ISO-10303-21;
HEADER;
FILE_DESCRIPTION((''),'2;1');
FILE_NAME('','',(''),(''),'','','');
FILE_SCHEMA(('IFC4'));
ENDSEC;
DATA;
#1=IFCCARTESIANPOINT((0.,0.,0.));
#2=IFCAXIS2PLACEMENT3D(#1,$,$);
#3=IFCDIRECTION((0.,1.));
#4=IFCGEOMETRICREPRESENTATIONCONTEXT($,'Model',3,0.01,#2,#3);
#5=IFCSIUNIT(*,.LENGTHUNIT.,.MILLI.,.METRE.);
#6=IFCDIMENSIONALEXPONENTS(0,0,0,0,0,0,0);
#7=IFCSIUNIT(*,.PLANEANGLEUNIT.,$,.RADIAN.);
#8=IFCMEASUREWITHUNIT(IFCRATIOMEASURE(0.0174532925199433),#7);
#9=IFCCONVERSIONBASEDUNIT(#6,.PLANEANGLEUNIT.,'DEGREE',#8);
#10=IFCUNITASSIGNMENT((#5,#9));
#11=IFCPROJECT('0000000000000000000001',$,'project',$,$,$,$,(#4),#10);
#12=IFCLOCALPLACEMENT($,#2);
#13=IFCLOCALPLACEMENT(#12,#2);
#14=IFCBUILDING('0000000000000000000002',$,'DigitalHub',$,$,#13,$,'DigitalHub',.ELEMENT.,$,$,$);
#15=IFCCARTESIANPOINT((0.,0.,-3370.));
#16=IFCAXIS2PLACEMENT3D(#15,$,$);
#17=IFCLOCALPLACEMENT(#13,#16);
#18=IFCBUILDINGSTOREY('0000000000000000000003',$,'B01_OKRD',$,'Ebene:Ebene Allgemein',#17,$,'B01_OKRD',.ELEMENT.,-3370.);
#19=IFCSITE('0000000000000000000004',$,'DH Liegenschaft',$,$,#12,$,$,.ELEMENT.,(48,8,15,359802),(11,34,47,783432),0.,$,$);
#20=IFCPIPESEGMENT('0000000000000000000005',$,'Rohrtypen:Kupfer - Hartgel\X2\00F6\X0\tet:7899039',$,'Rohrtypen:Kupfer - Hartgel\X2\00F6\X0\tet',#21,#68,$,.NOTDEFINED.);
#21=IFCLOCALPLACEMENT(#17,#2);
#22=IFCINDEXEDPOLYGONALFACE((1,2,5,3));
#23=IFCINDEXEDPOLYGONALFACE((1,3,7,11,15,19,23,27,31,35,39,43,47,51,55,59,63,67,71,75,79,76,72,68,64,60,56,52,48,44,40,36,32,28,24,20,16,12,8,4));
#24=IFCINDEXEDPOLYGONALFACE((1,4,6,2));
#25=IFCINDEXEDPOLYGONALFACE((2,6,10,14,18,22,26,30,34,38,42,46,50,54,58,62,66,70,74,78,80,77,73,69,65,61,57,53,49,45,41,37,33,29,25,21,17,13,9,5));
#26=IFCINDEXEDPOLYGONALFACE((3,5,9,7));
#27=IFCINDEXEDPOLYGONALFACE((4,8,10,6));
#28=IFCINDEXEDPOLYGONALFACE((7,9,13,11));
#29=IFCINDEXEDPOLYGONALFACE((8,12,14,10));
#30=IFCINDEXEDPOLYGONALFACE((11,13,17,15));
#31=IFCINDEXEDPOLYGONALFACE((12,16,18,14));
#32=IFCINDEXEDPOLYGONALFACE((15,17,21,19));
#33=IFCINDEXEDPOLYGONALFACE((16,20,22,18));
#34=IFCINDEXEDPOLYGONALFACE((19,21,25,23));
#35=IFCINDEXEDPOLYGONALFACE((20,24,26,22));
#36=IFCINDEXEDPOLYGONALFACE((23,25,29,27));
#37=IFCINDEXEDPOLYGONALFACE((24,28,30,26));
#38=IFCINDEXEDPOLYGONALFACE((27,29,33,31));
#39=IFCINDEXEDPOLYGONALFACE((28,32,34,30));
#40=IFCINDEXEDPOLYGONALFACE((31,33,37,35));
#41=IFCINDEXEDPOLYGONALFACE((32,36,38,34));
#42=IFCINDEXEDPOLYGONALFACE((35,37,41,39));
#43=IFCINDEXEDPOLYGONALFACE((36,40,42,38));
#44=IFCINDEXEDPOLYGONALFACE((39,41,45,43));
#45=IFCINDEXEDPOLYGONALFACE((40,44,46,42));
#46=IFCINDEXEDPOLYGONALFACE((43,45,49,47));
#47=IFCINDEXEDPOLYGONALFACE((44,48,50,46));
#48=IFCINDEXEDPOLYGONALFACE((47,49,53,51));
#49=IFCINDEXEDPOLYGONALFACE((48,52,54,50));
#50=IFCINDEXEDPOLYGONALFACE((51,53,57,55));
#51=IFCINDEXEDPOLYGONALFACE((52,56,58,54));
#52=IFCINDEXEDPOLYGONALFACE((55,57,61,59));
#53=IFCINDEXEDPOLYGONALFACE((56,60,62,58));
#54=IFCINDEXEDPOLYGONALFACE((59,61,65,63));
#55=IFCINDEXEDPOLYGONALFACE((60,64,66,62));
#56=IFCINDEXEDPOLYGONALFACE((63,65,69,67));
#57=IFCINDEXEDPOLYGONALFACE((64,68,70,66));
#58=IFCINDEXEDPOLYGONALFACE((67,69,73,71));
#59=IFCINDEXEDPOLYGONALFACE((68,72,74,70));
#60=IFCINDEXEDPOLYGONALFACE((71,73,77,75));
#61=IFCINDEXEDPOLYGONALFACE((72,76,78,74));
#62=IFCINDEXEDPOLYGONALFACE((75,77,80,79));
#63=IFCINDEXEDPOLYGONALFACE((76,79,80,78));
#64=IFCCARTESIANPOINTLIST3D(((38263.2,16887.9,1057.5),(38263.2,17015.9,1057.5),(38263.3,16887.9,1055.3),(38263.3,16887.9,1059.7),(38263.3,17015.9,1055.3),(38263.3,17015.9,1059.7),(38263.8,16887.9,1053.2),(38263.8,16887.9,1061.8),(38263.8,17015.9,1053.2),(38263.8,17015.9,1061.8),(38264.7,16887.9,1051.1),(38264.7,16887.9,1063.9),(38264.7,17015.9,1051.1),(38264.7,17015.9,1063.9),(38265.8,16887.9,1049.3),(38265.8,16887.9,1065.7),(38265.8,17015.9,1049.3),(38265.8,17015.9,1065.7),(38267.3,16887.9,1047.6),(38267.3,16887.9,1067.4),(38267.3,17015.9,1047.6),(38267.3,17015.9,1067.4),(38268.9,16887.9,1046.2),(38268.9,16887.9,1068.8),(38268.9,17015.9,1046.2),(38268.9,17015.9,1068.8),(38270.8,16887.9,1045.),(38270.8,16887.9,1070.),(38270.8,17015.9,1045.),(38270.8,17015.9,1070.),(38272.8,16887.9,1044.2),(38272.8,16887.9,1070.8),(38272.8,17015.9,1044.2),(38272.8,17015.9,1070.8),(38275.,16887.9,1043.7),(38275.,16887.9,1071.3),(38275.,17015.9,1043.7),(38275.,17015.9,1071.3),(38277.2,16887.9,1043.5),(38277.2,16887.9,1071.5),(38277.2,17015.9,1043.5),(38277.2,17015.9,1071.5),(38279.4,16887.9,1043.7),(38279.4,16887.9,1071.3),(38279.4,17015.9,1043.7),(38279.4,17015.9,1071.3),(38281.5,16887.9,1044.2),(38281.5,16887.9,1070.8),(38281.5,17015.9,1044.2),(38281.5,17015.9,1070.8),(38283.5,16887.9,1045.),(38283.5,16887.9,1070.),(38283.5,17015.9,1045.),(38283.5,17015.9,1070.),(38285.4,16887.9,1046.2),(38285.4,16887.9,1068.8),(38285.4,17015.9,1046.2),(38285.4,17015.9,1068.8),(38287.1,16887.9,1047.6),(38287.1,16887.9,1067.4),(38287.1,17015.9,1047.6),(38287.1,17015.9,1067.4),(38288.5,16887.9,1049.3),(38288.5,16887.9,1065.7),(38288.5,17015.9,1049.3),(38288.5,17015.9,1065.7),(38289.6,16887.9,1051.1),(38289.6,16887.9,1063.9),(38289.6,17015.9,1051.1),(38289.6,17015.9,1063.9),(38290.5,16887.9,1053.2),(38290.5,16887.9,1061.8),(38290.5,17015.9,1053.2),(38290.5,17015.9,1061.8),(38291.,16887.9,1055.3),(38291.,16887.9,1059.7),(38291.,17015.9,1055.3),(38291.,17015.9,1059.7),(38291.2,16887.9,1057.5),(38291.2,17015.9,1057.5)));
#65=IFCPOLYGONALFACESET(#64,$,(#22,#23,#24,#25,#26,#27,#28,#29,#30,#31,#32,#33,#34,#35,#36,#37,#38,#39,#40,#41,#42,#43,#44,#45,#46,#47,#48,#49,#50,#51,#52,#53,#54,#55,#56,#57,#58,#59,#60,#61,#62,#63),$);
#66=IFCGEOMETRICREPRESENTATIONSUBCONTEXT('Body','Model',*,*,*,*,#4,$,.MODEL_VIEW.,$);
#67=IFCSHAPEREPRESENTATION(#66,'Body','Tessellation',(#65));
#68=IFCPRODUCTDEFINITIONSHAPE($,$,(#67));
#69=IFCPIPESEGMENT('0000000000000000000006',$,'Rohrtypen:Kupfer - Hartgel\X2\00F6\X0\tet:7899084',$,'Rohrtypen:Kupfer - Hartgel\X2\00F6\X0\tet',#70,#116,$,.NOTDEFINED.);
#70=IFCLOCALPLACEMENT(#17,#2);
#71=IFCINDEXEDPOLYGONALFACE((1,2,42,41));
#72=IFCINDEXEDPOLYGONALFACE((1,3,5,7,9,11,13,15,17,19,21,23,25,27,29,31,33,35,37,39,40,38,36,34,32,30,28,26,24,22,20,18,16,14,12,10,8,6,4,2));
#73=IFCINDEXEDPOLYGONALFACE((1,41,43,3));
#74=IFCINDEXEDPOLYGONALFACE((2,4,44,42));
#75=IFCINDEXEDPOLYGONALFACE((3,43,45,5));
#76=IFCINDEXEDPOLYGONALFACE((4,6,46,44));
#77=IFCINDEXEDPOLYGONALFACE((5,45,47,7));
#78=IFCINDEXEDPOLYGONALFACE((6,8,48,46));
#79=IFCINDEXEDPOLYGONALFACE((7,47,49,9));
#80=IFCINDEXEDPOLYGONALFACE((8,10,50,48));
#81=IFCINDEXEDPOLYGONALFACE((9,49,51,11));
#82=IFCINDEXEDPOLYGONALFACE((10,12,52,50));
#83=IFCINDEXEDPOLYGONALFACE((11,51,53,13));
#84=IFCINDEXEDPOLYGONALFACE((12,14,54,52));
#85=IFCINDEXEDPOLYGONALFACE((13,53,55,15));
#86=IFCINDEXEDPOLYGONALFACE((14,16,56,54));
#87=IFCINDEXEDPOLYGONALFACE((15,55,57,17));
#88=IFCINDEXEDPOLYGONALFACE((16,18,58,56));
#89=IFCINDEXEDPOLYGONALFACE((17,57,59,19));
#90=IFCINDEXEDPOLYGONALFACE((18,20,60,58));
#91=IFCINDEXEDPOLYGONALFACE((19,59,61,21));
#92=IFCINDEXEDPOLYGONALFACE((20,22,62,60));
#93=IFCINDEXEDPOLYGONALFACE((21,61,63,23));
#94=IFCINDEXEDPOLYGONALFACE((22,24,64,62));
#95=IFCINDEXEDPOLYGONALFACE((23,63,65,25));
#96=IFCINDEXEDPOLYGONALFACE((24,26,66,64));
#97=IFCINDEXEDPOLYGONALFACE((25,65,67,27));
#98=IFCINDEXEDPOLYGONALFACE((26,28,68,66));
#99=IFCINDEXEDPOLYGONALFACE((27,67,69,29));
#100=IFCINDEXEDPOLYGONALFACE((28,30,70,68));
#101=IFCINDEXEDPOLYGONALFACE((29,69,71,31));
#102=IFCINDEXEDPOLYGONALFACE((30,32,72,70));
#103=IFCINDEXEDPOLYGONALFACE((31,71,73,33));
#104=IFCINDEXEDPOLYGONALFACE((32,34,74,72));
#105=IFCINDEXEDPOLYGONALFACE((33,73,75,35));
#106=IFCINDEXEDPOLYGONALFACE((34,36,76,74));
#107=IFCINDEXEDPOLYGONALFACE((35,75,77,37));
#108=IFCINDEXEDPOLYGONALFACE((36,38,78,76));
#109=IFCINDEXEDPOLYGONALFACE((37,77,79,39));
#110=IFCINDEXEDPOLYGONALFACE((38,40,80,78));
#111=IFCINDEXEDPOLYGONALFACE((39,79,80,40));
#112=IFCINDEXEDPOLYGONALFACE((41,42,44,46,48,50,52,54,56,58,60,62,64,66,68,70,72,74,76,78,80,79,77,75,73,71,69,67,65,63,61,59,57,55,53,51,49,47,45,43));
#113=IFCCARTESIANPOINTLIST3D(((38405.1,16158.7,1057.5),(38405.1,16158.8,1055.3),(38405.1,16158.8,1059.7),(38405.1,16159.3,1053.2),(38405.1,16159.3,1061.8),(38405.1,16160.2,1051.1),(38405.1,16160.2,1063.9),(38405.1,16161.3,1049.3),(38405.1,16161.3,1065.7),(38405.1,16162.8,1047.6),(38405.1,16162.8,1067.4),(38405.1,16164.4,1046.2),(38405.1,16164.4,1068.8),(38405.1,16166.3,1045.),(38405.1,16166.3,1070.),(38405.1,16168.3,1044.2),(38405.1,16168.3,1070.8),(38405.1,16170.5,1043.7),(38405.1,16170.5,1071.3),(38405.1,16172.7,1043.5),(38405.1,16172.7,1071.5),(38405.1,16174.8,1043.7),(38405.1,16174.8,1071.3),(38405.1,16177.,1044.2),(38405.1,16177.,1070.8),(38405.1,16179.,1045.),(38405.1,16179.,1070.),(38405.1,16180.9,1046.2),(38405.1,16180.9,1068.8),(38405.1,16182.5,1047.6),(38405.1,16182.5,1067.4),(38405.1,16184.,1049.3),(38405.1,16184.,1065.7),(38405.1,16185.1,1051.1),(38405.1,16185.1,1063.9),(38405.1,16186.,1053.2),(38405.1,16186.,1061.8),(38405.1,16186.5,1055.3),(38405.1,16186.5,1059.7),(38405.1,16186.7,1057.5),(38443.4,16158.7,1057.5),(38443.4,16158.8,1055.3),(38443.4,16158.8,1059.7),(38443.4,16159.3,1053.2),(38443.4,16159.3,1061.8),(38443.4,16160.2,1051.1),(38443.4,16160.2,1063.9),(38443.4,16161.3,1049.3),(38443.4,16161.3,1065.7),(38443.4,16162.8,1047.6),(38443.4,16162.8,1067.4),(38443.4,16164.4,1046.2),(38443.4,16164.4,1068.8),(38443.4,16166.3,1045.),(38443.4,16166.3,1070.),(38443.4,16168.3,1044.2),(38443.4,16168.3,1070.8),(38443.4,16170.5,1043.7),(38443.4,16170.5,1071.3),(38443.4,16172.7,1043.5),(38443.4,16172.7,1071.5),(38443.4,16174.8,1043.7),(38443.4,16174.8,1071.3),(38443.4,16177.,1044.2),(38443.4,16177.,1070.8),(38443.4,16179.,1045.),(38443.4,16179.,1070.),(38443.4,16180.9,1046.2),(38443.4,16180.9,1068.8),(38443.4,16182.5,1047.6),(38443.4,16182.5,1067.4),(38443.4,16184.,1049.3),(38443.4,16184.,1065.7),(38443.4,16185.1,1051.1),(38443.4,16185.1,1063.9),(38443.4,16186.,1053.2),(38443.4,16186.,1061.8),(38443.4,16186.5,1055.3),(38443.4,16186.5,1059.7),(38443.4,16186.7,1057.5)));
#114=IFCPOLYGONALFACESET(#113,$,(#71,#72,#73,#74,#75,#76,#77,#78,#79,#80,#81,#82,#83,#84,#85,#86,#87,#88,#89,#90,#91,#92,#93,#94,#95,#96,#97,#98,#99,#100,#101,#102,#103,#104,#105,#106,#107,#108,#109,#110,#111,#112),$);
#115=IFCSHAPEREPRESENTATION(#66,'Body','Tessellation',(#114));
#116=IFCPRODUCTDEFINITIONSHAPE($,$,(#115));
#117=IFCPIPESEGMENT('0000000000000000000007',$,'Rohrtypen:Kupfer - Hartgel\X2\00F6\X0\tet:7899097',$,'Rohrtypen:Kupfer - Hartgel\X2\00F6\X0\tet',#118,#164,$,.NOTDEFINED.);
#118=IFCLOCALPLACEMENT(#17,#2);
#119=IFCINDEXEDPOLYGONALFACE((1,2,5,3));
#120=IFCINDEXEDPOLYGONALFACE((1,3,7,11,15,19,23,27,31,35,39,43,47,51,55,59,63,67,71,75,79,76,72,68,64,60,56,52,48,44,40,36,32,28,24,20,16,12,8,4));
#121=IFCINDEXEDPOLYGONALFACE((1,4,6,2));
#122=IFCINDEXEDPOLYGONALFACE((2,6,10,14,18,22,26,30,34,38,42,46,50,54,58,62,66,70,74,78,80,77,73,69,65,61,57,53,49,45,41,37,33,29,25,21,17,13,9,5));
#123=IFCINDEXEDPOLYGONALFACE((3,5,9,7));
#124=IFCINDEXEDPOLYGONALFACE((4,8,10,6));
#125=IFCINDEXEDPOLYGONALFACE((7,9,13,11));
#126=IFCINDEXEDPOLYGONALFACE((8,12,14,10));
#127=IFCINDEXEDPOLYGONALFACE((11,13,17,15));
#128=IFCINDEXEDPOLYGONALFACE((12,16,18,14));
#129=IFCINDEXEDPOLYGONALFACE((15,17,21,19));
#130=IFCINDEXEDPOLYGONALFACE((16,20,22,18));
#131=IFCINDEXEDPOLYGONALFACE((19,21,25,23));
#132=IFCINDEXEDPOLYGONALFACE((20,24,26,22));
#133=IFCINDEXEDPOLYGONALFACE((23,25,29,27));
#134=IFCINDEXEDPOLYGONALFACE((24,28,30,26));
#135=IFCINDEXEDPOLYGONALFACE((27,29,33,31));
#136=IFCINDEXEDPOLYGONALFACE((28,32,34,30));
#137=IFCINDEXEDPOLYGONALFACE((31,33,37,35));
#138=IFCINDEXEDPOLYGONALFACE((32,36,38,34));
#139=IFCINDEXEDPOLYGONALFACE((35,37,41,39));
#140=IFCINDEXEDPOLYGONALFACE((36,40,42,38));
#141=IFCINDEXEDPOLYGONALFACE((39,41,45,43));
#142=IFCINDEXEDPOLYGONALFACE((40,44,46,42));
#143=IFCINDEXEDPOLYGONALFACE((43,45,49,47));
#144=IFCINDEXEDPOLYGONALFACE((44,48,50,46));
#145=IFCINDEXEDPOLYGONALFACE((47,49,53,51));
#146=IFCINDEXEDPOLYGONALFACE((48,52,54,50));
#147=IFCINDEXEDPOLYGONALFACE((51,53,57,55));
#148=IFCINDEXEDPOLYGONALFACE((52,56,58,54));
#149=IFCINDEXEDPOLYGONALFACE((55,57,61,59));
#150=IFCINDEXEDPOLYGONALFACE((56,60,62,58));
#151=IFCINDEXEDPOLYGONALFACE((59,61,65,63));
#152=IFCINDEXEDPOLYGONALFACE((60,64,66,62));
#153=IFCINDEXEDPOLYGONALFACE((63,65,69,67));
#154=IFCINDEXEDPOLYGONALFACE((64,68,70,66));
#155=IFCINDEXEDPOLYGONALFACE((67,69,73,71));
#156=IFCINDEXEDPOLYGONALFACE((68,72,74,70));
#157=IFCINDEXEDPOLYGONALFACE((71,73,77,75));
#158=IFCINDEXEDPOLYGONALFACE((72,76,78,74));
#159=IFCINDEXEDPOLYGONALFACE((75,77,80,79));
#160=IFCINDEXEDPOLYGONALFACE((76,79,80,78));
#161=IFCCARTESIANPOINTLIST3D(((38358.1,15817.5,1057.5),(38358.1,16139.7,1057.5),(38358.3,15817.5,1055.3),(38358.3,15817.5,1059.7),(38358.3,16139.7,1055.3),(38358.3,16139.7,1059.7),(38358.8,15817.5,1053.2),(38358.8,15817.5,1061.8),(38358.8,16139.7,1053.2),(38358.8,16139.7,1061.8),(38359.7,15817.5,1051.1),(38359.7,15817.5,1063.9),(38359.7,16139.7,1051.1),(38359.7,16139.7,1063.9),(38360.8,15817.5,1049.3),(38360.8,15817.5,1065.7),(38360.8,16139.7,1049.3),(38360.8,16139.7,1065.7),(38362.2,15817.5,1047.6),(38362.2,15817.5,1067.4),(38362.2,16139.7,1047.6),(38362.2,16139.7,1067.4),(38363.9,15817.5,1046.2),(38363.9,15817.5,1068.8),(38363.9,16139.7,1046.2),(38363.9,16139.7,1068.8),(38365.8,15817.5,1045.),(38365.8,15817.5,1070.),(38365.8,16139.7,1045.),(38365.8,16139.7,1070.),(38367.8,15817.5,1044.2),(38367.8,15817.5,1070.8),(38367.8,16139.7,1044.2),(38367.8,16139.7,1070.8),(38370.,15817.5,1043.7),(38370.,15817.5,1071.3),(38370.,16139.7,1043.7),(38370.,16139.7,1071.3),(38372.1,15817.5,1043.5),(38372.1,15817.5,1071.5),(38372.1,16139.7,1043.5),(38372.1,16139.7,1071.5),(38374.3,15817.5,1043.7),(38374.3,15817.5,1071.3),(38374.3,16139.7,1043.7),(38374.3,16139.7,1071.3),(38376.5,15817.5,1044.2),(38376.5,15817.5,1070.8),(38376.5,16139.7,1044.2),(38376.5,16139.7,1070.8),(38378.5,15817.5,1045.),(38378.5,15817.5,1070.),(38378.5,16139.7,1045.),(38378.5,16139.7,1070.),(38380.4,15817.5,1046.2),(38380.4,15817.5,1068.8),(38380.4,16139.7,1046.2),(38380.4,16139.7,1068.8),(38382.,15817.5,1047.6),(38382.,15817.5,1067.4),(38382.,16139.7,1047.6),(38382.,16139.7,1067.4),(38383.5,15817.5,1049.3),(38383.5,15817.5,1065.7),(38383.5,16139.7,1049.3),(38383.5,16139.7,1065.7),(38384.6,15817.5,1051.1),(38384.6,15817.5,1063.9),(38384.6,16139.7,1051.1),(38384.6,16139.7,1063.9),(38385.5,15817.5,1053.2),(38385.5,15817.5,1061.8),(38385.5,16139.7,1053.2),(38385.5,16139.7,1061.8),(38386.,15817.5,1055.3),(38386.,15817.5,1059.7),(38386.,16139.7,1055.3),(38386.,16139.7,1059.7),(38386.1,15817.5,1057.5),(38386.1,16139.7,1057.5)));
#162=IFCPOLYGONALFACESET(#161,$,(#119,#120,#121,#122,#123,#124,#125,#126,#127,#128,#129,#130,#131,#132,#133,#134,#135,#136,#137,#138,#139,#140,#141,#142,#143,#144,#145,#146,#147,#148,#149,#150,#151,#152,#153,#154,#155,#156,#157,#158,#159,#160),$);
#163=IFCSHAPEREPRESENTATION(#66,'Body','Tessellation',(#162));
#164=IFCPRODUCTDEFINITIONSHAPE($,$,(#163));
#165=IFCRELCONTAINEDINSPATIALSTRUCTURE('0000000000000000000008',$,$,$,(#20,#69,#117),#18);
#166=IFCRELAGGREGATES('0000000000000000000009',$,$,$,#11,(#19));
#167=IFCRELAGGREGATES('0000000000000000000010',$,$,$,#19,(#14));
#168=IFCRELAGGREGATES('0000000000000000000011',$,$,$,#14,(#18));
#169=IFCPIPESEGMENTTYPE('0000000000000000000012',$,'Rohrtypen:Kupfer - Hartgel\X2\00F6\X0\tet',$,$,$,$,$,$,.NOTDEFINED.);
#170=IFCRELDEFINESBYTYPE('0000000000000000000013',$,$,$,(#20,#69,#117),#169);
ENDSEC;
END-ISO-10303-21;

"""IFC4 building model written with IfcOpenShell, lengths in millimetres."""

from ifc_helpers import new_model, entity, si_unit, converted_unit, direction, frame, origin, place, context, subcontext, project, spatial, indexed_curve, outline, extrude, type_object, element, save


model = new_model("IFC4")

# Units and contexts
model_context = context("Model", 3, precision=0.01, world=origin(), true_north=direction((0.0, 1.0)))
body_context = subcontext(model_context, "Body", "Model", "MODEL_VIEW")
ifc_project = project(units=[si_unit("LENGTHUNIT", "METRE", prefix="MILLI"), converted_unit("PLANEANGLEUNIT", "DEGREE", entity("IfcRatioMeasure", 0.0174532925199433), si_unit("PLANEANGLEUNIT", "RADIAN"), dimensions=[0, 0, 0, 0, 0, 0, 0])], contexts=[model_context])

# Site, building, storey
site_placement = place(None, origin())
site = spatial("IfcSite", under=ifc_project, at=site_placement, Name="DH Liegenschaft", CompositionType="ELEMENT", RefLatitude=(48, 8, 15, 359802), RefLongitude=(11, 34, 47, 783432), RefElevation=0.0)
building_placement = place(site_placement, origin())
building = spatial("IfcBuilding", under=site, at=building_placement, Name="DigitalHub", LongName="DigitalHub", CompositionType="ELEMENT")
storey_placement = place(building_placement, frame((0.0, 0.0, -3370.0)))
storey = spatial("IfcBuildingStorey", under=building, at=storey_placement, Name="B01_OKRD", ObjectType="Ebene:Ebene Allgemein", LongName="B01_OKRD", CompositionType="ELEMENT", Elevation=-3370.0)

# Pipe segments
pipe_segment_type = type_object("IfcPipeSegmentType", Name="Rohrtypen:Kupfer - Hartgelötet", PredefinedType="NOTDEFINED")
pipe_segment_1_placement = place(storey_placement, frame((38261.6, 16887.9, 1041.9)))
element("IfcPipeSegment", 1, at=pipe_segment_1_placement, inside=storey, type_object=pipe_segment_type, Name="Rohrtypen:Kupfer - Hartgelötet:7899039", ObjectType="Rohrtypen:Kupfer - Hartgelötet", PredefinedType="NOTDEFINED", context=body_context, shape_type="SweptSolid", body=[
    extrude(outline(indexed_curve([(14.0, 0.0), (13.8, 2.2), (13.3, 4.3), (12.5, 6.4), (11.3, 8.2), (9.9, 9.9), (8.2, 11.3), (6.4, 12.5), (4.3, 13.3), (2.2, 13.8), (0.0, 14.0), (-2.2, 13.8), (-4.3, 13.3), (-6.4, 12.5), (-8.2, 11.3), (-9.9, 9.9), (-11.3, 8.2), (-12.5, 6.4), (-13.3, 4.3), (-13.8, 2.2), (-14.0, 0.0), (-13.8, -2.2), (-13.3, -4.3), (-12.5, -6.4), (-11.3, -8.2), (-9.9, -9.9), (-8.2, -11.3), (-6.4, -12.5), (-4.3, -13.3), (-2.2, -13.8), (0.0, -14.0), (2.2, -13.8), (4.3, -13.3), (6.4, -12.5), (8.2, -11.3), (9.9, -9.9), (11.3, -8.2), (12.5, -6.4), (13.3, -4.3), (13.8, -2.2), (14.0, 0.0)], self_intersect=False)), frame((15.6, 0.0, 15.6), z_axis=(0.0, 1.0, 0.0), x_axis=(1.0, 0.0, 0.0)), (0.0, 0.0, 1.0), 128.0),
])
pipe_segment_2_placement = place(storey_placement, frame((38405.1, 16157.1, 1041.9)))
element("IfcPipeSegment", 2, at=pipe_segment_2_placement, inside=storey, type_object=pipe_segment_type, Name="Rohrtypen:Kupfer - Hartgelötet:7899084", ObjectType="Rohrtypen:Kupfer - Hartgelötet", PredefinedType="NOTDEFINED", context=body_context, shape_type="SweptSolid", body=[
    extrude(outline(indexed_curve([(14.0, 0.0), (13.8, 2.2), (13.3, 4.3), (12.5, 6.4), (11.3, 8.2), (9.9, 9.9), (8.2, 11.3), (6.4, 12.5), (4.3, 13.3), (2.2, 13.8), (0.0, 14.0), (-2.2, 13.8), (-4.3, 13.3), (-6.4, 12.5), (-8.2, 11.3), (-9.9, 9.9), (-11.3, 8.2), (-12.5, 6.4), (-13.3, 4.3), (-13.8, 2.2), (-14.0, 0.0), (-13.8, -2.2), (-13.3, -4.3), (-12.5, -6.4), (-11.3, -8.2), (-9.9, -9.9), (-8.2, -11.3), (-6.4, -12.5), (-4.3, -13.3), (-2.2, -13.8), (0.0, -14.0), (2.2, -13.8), (4.3, -13.3), (6.4, -12.5), (8.2, -11.3), (9.9, -9.9), (11.3, -8.2), (12.5, -6.4), (13.3, -4.3), (13.8, -2.2), (14.0, 0.0)], self_intersect=False)), frame((0.0, 15.6, 15.6), z_axis=(1.0, 0.0, 0.0), x_axis=(0.0, -1.0, 0.0)), (0.0, 0.0, 1.0), 38.3),
])
pipe_segment_3_placement = place(storey_placement, frame((38356.6, 15817.5, 1041.9)))
element("IfcPipeSegment", 3, at=pipe_segment_3_placement, inside=storey, type_object=pipe_segment_type, Name="Rohrtypen:Kupfer - Hartgelötet:7899097", ObjectType="Rohrtypen:Kupfer - Hartgelötet", PredefinedType="NOTDEFINED", context=body_context, shape_type="SweptSolid", body=[
    extrude(outline(indexed_curve([(14.0, 0.0), (13.8, 2.2), (13.3, 4.3), (12.5, 6.4), (11.3, 8.2), (9.9, 9.9), (8.2, 11.3), (6.4, 12.5), (4.3, 13.3), (2.2, 13.8), (0.0, 14.0), (-2.2, 13.8), (-4.3, 13.3), (-6.4, 12.5), (-8.2, 11.3), (-9.9, 9.9), (-11.3, 8.2), (-12.5, 6.4), (-13.3, 4.3), (-13.8, 2.2), (-14.0, 0.0), (-13.8, -2.2), (-13.3, -4.3), (-12.5, -6.4), (-11.3, -8.2), (-9.9, -9.9), (-8.2, -11.3), (-6.4, -12.5), (-4.3, -13.3), (-2.2, -13.8), (0.0, -14.0), (2.2, -13.8), (4.3, -13.3), (6.4, -12.5), (8.2, -11.3), (9.9, -9.9), (11.3, -8.2), (12.5, -6.4), (13.3, -4.3), (13.8, -2.2), (14.0, 0.0)], self_intersect=False)), frame((15.6, 0.0, 15.6), z_axis=(0.0, 1.0, 0.0), x_axis=(1.0, 0.0, 0.0)), (0.0, 0.0, 1.0), 322.2),
])

save(model, "model.ifc")
